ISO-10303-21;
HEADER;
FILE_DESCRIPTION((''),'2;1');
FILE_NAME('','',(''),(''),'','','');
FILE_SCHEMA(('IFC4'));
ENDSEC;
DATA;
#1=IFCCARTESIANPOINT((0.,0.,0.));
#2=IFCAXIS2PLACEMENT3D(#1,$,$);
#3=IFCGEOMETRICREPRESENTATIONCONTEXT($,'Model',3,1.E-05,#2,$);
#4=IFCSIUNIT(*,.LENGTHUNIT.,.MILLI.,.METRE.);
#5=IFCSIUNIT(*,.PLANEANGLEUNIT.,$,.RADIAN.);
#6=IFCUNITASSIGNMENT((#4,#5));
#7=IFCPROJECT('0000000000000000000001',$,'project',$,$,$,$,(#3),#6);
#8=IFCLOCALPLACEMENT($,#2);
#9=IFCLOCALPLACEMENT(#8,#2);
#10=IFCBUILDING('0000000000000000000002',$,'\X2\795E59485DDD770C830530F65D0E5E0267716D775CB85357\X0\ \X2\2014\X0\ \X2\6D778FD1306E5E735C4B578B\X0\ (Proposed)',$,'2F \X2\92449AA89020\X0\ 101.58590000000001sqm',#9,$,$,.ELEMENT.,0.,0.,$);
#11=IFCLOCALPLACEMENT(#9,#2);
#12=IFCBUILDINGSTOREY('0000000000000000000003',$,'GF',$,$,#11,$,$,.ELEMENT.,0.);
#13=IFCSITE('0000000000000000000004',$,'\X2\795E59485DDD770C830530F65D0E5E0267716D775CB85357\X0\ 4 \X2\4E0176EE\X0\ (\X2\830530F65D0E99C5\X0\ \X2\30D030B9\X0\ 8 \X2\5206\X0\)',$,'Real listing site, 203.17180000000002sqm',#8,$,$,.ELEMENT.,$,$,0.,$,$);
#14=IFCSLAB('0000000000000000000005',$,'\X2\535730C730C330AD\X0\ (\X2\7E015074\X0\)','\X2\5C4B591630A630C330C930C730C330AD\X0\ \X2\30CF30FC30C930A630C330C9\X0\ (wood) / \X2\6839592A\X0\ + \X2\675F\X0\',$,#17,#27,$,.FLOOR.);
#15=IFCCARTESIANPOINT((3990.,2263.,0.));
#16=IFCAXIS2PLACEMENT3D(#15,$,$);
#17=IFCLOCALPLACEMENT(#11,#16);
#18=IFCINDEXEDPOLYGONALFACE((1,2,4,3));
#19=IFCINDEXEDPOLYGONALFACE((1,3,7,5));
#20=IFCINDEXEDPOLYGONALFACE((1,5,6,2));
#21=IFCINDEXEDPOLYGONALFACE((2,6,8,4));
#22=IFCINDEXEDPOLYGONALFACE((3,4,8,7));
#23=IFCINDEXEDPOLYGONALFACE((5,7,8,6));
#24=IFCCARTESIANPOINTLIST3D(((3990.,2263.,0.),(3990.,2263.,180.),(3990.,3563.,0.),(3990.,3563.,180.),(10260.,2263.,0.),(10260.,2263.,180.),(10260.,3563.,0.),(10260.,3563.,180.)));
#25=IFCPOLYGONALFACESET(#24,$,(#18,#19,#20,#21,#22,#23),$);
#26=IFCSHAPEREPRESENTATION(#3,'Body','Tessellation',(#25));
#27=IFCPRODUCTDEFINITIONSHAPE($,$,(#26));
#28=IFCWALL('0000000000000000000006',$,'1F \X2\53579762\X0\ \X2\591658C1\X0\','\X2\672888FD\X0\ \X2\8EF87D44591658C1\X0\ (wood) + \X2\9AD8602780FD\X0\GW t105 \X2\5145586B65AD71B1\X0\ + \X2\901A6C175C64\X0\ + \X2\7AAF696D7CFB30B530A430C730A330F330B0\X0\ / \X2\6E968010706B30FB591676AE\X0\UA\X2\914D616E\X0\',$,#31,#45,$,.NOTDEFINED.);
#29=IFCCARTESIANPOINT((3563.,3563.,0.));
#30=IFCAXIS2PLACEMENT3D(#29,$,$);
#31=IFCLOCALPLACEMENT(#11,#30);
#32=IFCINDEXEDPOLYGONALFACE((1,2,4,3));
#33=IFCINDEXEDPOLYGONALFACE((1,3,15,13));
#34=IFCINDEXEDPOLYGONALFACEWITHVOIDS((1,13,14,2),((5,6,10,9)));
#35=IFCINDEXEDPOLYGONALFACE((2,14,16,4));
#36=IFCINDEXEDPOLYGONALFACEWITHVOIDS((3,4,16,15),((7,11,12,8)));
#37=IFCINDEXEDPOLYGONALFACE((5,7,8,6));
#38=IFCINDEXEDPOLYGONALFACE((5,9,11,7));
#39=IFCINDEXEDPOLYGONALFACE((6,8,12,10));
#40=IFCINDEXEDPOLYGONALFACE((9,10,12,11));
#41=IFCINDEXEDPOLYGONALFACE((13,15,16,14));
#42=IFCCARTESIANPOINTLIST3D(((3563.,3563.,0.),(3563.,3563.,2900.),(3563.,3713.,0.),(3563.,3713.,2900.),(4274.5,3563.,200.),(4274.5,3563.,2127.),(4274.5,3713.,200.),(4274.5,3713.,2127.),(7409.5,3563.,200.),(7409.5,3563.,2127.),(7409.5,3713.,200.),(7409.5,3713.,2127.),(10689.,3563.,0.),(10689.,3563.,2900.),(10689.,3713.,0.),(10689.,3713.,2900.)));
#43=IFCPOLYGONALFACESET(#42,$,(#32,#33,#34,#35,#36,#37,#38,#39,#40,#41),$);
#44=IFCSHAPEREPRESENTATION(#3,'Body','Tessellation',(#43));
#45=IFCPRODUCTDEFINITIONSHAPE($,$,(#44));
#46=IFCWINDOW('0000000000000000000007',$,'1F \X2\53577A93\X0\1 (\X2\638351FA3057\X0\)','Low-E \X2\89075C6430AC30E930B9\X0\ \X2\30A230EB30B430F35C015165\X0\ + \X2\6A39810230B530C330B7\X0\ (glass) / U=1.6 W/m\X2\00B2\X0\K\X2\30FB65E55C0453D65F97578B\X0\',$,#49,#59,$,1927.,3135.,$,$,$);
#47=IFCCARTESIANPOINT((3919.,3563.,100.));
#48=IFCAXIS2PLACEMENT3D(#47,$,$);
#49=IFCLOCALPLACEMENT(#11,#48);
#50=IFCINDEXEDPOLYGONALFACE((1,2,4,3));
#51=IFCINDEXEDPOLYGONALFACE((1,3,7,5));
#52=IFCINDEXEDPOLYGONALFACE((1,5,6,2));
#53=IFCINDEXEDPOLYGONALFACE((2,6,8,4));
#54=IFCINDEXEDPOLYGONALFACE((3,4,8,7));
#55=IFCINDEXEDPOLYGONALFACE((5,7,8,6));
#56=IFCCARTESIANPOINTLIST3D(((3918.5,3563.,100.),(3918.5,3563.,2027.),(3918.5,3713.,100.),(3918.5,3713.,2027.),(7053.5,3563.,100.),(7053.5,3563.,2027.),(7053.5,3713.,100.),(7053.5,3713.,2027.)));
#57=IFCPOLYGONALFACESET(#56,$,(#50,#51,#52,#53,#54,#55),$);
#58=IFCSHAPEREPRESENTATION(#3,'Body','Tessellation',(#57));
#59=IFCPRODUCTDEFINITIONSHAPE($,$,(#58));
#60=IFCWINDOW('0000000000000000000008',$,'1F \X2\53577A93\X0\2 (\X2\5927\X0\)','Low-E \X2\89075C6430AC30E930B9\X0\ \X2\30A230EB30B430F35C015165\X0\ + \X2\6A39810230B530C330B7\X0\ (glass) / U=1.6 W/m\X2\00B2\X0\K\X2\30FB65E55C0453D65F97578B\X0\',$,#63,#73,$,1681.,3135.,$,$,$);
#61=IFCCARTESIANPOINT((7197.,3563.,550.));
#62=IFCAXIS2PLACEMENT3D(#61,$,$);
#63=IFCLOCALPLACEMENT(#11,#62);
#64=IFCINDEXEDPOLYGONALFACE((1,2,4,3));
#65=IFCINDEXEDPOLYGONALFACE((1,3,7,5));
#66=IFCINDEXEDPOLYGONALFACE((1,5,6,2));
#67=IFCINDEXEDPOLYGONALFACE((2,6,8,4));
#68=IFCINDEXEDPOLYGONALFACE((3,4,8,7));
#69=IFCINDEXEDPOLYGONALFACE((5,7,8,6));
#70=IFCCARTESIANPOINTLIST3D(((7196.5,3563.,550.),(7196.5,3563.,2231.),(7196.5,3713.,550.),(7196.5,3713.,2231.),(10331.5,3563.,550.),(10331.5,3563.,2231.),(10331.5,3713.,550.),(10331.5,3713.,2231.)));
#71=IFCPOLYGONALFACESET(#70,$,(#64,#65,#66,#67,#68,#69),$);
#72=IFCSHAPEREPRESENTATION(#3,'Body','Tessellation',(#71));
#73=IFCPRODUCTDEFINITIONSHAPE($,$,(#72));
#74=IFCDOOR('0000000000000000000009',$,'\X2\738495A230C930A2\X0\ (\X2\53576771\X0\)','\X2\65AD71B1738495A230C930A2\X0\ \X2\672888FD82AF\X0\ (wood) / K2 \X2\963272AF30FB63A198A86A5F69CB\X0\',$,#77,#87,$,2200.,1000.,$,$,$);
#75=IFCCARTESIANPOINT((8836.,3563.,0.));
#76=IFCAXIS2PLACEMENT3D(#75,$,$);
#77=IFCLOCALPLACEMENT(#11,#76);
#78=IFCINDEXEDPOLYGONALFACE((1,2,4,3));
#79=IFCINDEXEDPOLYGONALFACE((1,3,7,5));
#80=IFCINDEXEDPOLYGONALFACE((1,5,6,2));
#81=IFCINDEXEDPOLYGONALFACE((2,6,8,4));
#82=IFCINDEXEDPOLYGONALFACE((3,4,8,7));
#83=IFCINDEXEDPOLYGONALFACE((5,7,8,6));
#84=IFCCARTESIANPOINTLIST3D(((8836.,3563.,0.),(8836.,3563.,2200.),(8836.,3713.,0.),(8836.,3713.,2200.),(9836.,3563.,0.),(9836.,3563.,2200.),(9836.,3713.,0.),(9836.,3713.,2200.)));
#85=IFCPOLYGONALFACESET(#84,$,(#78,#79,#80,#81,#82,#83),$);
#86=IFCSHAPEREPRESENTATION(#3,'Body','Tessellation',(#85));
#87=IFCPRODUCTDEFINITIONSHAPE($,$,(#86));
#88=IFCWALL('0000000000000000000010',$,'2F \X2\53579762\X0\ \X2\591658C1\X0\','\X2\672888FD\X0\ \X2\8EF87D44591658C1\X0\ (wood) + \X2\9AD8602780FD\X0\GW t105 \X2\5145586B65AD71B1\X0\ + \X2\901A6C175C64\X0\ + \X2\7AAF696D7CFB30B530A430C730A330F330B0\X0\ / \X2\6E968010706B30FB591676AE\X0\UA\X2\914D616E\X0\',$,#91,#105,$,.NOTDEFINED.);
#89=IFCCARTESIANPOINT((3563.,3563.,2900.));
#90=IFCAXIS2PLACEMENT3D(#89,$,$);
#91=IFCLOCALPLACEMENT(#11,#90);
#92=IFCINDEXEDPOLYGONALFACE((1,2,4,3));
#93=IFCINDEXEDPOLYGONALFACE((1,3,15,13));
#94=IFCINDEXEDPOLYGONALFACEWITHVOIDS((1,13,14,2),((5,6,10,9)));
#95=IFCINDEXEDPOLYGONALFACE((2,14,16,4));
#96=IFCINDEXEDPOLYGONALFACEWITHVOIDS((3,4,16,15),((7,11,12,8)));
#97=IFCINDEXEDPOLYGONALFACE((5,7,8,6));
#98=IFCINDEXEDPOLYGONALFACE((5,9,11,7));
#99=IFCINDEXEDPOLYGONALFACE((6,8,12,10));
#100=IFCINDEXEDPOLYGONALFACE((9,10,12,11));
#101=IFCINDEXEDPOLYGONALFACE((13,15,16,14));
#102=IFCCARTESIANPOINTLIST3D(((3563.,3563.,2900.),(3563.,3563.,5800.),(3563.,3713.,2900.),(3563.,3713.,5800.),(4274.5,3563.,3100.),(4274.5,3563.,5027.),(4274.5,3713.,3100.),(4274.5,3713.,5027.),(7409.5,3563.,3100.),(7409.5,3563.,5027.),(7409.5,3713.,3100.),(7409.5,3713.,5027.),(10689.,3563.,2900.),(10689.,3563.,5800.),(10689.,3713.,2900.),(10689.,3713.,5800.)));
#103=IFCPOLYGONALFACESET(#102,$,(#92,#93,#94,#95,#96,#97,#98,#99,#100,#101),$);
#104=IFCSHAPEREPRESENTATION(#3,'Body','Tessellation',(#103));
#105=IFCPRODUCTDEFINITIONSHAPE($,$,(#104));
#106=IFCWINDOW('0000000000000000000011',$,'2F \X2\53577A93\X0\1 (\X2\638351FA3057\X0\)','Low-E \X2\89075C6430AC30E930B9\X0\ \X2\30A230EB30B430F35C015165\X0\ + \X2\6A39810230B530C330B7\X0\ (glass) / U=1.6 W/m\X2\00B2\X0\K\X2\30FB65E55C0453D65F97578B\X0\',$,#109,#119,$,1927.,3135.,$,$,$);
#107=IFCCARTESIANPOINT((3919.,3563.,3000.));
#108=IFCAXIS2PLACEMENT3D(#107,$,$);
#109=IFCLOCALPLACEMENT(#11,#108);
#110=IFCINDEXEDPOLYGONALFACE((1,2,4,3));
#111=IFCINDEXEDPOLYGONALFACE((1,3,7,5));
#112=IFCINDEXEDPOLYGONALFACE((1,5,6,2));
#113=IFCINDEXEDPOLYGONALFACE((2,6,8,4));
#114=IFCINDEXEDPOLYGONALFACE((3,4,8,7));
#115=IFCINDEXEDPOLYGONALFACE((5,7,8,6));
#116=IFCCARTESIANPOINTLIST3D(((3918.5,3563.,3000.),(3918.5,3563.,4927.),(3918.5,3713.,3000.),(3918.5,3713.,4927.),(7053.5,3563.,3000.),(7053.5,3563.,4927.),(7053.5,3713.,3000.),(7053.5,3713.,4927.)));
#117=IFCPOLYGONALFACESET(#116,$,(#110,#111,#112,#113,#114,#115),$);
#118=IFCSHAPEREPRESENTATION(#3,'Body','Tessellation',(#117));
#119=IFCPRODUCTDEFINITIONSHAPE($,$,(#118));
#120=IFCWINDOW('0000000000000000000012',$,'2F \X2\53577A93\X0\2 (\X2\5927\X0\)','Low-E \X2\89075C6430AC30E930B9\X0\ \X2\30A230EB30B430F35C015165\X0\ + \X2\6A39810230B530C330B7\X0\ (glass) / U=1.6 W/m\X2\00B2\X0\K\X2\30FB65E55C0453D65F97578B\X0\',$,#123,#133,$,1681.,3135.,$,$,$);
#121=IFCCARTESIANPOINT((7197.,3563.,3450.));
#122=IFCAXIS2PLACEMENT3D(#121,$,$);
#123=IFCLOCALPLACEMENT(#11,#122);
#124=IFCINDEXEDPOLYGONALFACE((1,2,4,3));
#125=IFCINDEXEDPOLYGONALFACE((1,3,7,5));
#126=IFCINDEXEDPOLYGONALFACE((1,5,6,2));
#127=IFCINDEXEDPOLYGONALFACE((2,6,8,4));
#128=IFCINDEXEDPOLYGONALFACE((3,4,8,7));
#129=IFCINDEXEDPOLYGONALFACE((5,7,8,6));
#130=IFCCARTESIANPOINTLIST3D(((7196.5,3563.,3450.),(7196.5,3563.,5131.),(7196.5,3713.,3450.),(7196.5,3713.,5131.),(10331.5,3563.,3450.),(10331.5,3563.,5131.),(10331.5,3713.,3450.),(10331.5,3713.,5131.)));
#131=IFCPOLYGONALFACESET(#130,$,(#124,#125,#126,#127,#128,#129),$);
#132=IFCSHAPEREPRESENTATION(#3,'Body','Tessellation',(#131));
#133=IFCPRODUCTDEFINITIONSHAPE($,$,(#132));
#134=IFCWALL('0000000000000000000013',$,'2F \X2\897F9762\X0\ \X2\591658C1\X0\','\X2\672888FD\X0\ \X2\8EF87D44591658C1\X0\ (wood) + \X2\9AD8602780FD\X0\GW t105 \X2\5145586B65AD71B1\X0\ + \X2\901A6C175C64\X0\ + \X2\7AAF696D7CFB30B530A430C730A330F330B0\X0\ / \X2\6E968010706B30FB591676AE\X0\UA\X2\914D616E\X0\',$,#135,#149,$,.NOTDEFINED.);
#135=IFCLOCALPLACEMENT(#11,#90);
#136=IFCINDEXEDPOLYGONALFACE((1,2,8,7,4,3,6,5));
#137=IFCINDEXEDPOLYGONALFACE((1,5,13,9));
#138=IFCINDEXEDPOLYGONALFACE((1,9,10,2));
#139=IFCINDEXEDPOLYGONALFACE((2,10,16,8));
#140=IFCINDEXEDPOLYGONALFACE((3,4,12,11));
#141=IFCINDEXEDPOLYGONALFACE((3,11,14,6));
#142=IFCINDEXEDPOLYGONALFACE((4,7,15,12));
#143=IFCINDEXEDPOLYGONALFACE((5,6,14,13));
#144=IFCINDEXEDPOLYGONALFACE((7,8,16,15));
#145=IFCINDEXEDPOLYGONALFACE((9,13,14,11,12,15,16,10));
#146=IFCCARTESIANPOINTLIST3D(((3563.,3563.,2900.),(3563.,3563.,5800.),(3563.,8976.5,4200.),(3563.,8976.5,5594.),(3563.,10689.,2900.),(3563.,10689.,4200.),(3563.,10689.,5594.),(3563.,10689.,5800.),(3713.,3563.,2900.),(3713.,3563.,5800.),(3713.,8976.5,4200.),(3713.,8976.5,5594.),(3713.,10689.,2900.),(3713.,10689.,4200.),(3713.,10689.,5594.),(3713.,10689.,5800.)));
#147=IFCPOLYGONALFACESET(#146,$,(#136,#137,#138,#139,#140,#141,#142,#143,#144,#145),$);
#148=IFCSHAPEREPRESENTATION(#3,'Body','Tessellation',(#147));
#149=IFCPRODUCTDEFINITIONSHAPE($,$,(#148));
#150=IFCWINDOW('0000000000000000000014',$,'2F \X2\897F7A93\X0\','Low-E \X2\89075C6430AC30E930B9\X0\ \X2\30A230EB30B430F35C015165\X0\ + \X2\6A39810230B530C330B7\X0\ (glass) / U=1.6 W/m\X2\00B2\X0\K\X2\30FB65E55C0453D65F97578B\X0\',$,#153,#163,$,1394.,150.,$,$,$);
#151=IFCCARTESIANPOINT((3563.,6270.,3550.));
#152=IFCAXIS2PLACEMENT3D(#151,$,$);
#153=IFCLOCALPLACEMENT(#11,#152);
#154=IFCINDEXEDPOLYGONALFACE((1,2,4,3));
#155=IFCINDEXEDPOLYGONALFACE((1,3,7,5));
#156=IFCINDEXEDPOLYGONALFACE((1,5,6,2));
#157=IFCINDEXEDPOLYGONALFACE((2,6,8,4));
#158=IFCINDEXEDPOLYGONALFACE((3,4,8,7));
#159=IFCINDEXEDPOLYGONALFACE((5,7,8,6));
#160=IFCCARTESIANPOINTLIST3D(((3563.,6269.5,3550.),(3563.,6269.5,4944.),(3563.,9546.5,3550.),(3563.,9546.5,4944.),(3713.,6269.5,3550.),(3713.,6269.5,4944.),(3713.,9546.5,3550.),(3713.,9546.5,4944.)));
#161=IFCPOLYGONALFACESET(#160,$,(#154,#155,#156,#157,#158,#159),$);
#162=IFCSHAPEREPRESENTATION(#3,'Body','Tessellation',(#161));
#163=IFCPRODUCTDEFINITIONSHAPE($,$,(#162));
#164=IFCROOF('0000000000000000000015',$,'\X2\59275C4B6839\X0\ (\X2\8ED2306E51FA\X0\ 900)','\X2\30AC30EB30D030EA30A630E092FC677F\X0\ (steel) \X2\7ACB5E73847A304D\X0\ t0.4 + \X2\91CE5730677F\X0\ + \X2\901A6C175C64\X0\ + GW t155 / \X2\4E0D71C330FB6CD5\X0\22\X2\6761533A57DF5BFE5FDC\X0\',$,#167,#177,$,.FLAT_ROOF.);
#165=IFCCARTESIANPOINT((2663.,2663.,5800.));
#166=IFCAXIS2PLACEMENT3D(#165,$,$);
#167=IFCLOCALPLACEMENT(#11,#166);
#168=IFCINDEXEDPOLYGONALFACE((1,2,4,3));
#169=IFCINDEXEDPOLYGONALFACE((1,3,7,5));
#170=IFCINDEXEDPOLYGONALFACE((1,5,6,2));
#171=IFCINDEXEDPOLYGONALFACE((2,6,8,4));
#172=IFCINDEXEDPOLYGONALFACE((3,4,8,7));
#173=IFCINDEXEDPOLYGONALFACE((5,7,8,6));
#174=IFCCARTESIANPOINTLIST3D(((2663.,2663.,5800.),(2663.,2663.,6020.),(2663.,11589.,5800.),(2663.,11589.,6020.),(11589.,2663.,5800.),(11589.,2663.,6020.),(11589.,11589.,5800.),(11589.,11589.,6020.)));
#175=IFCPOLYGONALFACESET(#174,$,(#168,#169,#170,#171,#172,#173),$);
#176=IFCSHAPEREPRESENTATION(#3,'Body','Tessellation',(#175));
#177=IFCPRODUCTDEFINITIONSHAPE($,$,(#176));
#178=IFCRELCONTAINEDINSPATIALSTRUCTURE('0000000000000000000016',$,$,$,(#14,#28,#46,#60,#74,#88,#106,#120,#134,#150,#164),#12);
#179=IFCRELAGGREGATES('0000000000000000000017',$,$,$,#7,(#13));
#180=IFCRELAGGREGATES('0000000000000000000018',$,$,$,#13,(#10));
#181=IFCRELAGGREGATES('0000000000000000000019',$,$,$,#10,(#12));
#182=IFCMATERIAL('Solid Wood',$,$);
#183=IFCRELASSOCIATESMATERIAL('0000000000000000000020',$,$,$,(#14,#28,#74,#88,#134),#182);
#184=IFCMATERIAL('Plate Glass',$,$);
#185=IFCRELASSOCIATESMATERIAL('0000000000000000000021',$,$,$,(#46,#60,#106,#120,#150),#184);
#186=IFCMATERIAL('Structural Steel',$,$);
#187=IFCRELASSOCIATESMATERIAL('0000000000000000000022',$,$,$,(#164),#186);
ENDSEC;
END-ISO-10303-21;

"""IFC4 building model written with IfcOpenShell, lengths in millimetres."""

from ifc_helpers import new_model, si_unit, frame, frame_2d, origin, place, context, project, spatial, rectangle, extrude, material, element, fill, save


model = new_model("IFC4")

# Units and contexts
model_context = context("Model", 3, precision=1e-05, world=origin())
ifc_project = project(units=[si_unit("LENGTHUNIT", "METRE", prefix="MILLI"), si_unit("PLANEANGLEUNIT", "RADIAN")], contexts=[model_context])

# Site, building, storey
site_placement = place(None, origin())
site = spatial("IfcSite", under=ifc_project, at=site_placement, Name="神奈川県茅ヶ崎市東海岸南 4 丁目 (茅ヶ崎駅 バス 8 分)", ObjectType="Real listing site, 203.17180000000002sqm", CompositionType="ELEMENT", RefElevation=0.0)
building_placement = place(site_placement, origin())
building = spatial("IfcBuilding", under=site, at=building_placement, Name="神奈川県茅ヶ崎市東海岸南 — 海近の平屋型 (Proposed)", ObjectType="2F 鉄骨造 101.58590000000001sqm", CompositionType="ELEMENT", ElevationOfRefHeight=0.0, ElevationOfTerrain=0.0)
storey_placement = place(building_placement, origin())
storey = spatial("IfcBuildingStorey", under=building, at=storey_placement, Name="GF", CompositionType="ELEMENT", Elevation=0.0)

# Slab
ifc_material_1 = material(Name="Solid Wood")
slab_1_placement = place(storey_placement, frame((3990.0, 2263.0, 0.0)))
element("IfcSlab", 1, at=slab_1_placement, inside=storey, material=ifc_material_1, Name="南デッキ (縁側)", Description="屋外ウッドデッキ ハードウッド (wood) / 根太 + 束", PredefinedType="FLOOR", context=model_context, shape_type="SweptSolid", body=[
    extrude(rectangle(XDim=6270.0, YDim=1300.0, at=frame_2d((3135.0, 650.0))), frame((3990.0, 2263.0, 0.0)), (0.0, 0.0, 1.0), 180.0),
])

# Wall, openings, windows, door
wall_1_placement = place(storey_placement, frame((3563.0, 3563.0, 0.0)))
wall_1 = element("IfcWall", 2, at=wall_1_placement, inside=storey, material=ifc_material_1, Name="1F 南面 外壁", Description="木製 軸組外壁 (wood) + 高性能GW t105 充填断熱 + 通気層 + 窯業系サイディング / 準耐火・外皮UA配慮", PredefinedType="NOTDEFINED", context=model_context, shape_type="SweptSolid", body=[
    extrude(rectangle(XDim=7126.0, YDim=150.0, at=frame_2d((3563.0, 75.0))), frame((3563.0, 3563.0, 0.0)), (0.0, 0.0, 1.0), 2900.0),
])
opening_1_placement = place(storey_placement, frame((3919.0, 3563.0, 100.0)))
opening_1 = element("IfcOpeningElement", 3, at=opening_1_placement, cuts=wall_1, PredefinedType="NOTDEFINED", context=model_context, shape_type="SweptSolid", body=[
    extrude(rectangle(XDim=3135.0, YDim=150.0, at=frame_2d((1567.0, 75.0))), frame((3919.0, 3563.0, 100.0)), (0.0, 0.0, 1.0), 1927.0),
])
opening_2_placement = place(storey_placement, frame((7197.0, 3563.0, 550.0)))
opening_2 = element("IfcOpeningElement", 4, at=opening_2_placement, cuts=wall_1, PredefinedType="NOTDEFINED", context=model_context, shape_type="SweptSolid", body=[
    extrude(rectangle(XDim=3135.0, YDim=150.0, at=frame_2d((1567.0, 75.0))), frame((7197.0, 3563.0, 550.0)), (0.0, 0.0, 1.0), 1681.0),
])
opening_3_placement = place(storey_placement, frame((8836.0, 3563.0, 0.0)))
opening_3 = element("IfcOpeningElement", 5, at=opening_3_placement, cuts=wall_1, PredefinedType="NOTDEFINED", context=model_context, shape_type="SweptSolid", body=[
    extrude(rectangle(XDim=1000.0, YDim=150.0, at=frame_2d((500.0, 75.0))), frame((8836.0, 3563.0, 0.0)), (0.0, 0.0, 1.0), 2200.0),
])
ifc_material_2 = material(Name="Plate Glass")
window_1_placement = place(storey_placement, frame((3919.0, 3563.0, 100.0)))
window_1 = element("IfcWindow", 6, at=window_1_placement, inside=storey, material=ifc_material_2, Name="1F 南窓1 (掃出し)", Description="Low-E 複層ガラス アルゴン封入 + 樹脂サッシ (glass) / U=1.6 W/m²K・日射取得型", OverallHeight=1927.0, OverallWidth=3135.0, context=model_context, shape_type="SweptSolid", body=[
    extrude(rectangle(XDim=3135.0, YDim=150.0, at=frame_2d((1567.0, 75.0))), frame((3919.0, 3563.0, 100.0)), (0.0, 0.0, 1.0), 1927.0),
])
fill(opening_1, window_1)
window_2_placement = place(storey_placement, frame((7197.0, 3563.0, 550.0)))
window_2 = element("IfcWindow", 7, at=window_2_placement, inside=storey, material=ifc_material_2, Name="1F 南窓2 (大)", Description="Low-E 複層ガラス アルゴン封入 + 樹脂サッシ (glass) / U=1.6 W/m²K・日射取得型", OverallHeight=1681.0, OverallWidth=3135.0, context=model_context, shape_type="SweptSolid", body=[
    extrude(rectangle(XDim=3135.0, YDim=150.0, at=frame_2d((1567.0, 75.0))), frame((7197.0, 3563.0, 550.0)), (0.0, 0.0, 1.0), 1681.0),
])
fill(opening_2, window_2)
door_placement = place(storey_placement, frame((8836.0, 3563.0, 0.0)))
door = element("IfcDoor", 8, at=door_placement, inside=storey, material=ifc_material_1, Name="玄関ドア (南東)", Description="断熱玄関ドア 木製芯 (wood) / K2 防犯・採風機構", OverallHeight=2200.0, OverallWidth=1000.0, context=model_context, shape_type="SweptSolid", body=[
    extrude(rectangle(XDim=1000.0, YDim=150.0, at=frame_2d((500.0, 75.0))), frame((8836.0, 3563.0, 0.0)), (0.0, 0.0, 1.0), 2200.0),
])
fill(opening_3, door)

# Wall, openings, windows
wall_2_placement = place(storey_placement, frame((3563.0, 3563.0, 2900.0)))
wall_2 = element("IfcWall", 9, at=wall_2_placement, inside=storey, material=ifc_material_1, Name="2F 南面 外壁", Description="木製 軸組外壁 (wood) + 高性能GW t105 充填断熱 + 通気層 + 窯業系サイディング / 準耐火・外皮UA配慮", PredefinedType="NOTDEFINED", context=model_context, shape_type="SweptSolid", body=[
    extrude(rectangle(XDim=7126.0, YDim=150.0, at=frame_2d((3563.0, 75.0))), frame((3563.0, 3563.0, 2900.0)), (0.0, 0.0, 1.0), 2900.0),
])
opening_4_placement = place(storey_placement, frame((3919.0, 3563.0, 3000.0)))
opening_4 = element("IfcOpeningElement", 10, at=opening_4_placement, cuts=wall_2, PredefinedType="NOTDEFINED", context=model_context, shape_type="SweptSolid", body=[
    extrude(rectangle(XDim=3135.0, YDim=150.0, at=frame_2d((1567.0, 75.0))), frame((3919.0, 3563.0, 3000.0)), (0.0, 0.0, 1.0), 1927.0),
])
opening_5_placement = place(storey_placement, frame((7197.0, 3563.0, 3450.0)))
opening_5 = element("IfcOpeningElement", 11, at=opening_5_placement, cuts=wall_2, PredefinedType="NOTDEFINED", context=model_context, shape_type="SweptSolid", body=[
    extrude(rectangle(XDim=3135.0, YDim=150.0, at=frame_2d((1567.0, 75.0))), frame((7197.0, 3563.0, 3450.0)), (0.0, 0.0, 1.0), 1681.0),
])
window_3_placement = place(storey_placement, frame((3919.0, 3563.0, 3000.0)))
window_3 = element("IfcWindow", 12, at=window_3_placement, inside=storey, material=ifc_material_2, Name="2F 南窓1 (掃出し)", Description="Low-E 複層ガラス アルゴン封入 + 樹脂サッシ (glass) / U=1.6 W/m²K・日射取得型", OverallHeight=1927.0, OverallWidth=3135.0, context=model_context, shape_type="SweptSolid", body=[
    extrude(rectangle(XDim=3135.0, YDim=150.0, at=frame_2d((1567.0, 75.0))), frame((3919.0, 3563.0, 3000.0)), (0.0, 0.0, 1.0), 1927.0),
])
fill(opening_4, window_3)
window_4_placement = place(storey_placement, frame((7197.0, 3563.0, 3450.0)))
window_4 = element("IfcWindow", 13, at=window_4_placement, inside=storey, material=ifc_material_2, Name="2F 南窓2 (大)", Description="Low-E 複層ガラス アルゴン封入 + 樹脂サッシ (glass) / U=1.6 W/m²K・日射取得型", OverallHeight=1681.0, OverallWidth=3135.0, context=model_context, shape_type="SweptSolid", body=[
    extrude(rectangle(XDim=3135.0, YDim=150.0, at=frame_2d((1567.0, 75.0))), frame((7197.0, 3563.0, 3450.0)), (0.0, 0.0, 1.0), 1681.0),
])
fill(opening_5, window_4)

# Wall, opening, window
wall_3_placement = place(storey_placement, frame((3563.0, 3563.0, 2900.0)))
wall_3 = element("IfcWall", 14, at=wall_3_placement, inside=storey, material=ifc_material_1, Name="2F 西面 外壁", Description="木製 軸組外壁 (wood) + 高性能GW t105 充填断熱 + 通気層 + 窯業系サイディング / 準耐火・外皮UA配慮", PredefinedType="NOTDEFINED", context=model_context, shape_type="SweptSolid", body=[
    extrude(rectangle(XDim=150.0, YDim=7126.0, at=frame_2d((75.0, 3563.0))), frame((3563.0, 3563.0, 2900.0)), (0.0, 0.0, 1.0), 2900.0),
])
opening_6_placement = place(storey_placement, frame((3563.0, 6270.0, 3550.0)))
opening_6 = element("IfcOpeningElement", 15, at=opening_6_placement, cuts=wall_3, PredefinedType="NOTDEFINED", context=model_context, shape_type="SweptSolid", body=[
    extrude(rectangle(XDim=150.0, YDim=3277.0, at=frame_2d((75.0, 1638.0))), frame((3563.0, 6270.0, 3550.0)), (0.0, 0.0, 1.0), 1394.0),
])
window_5_placement = place(storey_placement, frame((3563.0, 6270.0, 3550.0)))
window_5 = element("IfcWindow", 16, at=window_5_placement, inside=storey, material=ifc_material_2, Name="2F 西窓", Description="Low-E 複層ガラス アルゴン封入 + 樹脂サッシ (glass) / U=1.6 W/m²K・日射取得型", OverallHeight=1394.0, OverallWidth=150.0, context=model_context, shape_type="SweptSolid", body=[
    extrude(rectangle(XDim=150.0, YDim=3277.0, at=frame_2d((75.0, 1638.0))), frame((3563.0, 6270.0, 3550.0)), (0.0, 0.0, 1.0), 1394.0),
])
fill(opening_6, window_5)

# Roof
ifc_material_3 = material(Name="Structural Steel")
roof_placement = place(storey_placement, frame((2663.0, 2663.0, 5800.0)))
element("IfcRoof", 17, at=roof_placement, inside=storey, material=ifc_material_3, Name="大屋根 (軒の出 900)", Description="ガルバリウム鋼板 (steel) 立平葺き t0.4 + 野地板 + 通気層 + GW t155 / 不燃・法22条区域対応", PredefinedType="FLAT_ROOF", context=model_context, shape_type="SweptSolid", body=[
    extrude(rectangle(XDim=8926.0, YDim=8926.0, at=frame_2d((4463.0, 4463.0))), frame((2663.0, 2663.0, 5800.0)), (0.0, 0.0, 1.0), 220.0),
])

save(model, "model.ifc")
